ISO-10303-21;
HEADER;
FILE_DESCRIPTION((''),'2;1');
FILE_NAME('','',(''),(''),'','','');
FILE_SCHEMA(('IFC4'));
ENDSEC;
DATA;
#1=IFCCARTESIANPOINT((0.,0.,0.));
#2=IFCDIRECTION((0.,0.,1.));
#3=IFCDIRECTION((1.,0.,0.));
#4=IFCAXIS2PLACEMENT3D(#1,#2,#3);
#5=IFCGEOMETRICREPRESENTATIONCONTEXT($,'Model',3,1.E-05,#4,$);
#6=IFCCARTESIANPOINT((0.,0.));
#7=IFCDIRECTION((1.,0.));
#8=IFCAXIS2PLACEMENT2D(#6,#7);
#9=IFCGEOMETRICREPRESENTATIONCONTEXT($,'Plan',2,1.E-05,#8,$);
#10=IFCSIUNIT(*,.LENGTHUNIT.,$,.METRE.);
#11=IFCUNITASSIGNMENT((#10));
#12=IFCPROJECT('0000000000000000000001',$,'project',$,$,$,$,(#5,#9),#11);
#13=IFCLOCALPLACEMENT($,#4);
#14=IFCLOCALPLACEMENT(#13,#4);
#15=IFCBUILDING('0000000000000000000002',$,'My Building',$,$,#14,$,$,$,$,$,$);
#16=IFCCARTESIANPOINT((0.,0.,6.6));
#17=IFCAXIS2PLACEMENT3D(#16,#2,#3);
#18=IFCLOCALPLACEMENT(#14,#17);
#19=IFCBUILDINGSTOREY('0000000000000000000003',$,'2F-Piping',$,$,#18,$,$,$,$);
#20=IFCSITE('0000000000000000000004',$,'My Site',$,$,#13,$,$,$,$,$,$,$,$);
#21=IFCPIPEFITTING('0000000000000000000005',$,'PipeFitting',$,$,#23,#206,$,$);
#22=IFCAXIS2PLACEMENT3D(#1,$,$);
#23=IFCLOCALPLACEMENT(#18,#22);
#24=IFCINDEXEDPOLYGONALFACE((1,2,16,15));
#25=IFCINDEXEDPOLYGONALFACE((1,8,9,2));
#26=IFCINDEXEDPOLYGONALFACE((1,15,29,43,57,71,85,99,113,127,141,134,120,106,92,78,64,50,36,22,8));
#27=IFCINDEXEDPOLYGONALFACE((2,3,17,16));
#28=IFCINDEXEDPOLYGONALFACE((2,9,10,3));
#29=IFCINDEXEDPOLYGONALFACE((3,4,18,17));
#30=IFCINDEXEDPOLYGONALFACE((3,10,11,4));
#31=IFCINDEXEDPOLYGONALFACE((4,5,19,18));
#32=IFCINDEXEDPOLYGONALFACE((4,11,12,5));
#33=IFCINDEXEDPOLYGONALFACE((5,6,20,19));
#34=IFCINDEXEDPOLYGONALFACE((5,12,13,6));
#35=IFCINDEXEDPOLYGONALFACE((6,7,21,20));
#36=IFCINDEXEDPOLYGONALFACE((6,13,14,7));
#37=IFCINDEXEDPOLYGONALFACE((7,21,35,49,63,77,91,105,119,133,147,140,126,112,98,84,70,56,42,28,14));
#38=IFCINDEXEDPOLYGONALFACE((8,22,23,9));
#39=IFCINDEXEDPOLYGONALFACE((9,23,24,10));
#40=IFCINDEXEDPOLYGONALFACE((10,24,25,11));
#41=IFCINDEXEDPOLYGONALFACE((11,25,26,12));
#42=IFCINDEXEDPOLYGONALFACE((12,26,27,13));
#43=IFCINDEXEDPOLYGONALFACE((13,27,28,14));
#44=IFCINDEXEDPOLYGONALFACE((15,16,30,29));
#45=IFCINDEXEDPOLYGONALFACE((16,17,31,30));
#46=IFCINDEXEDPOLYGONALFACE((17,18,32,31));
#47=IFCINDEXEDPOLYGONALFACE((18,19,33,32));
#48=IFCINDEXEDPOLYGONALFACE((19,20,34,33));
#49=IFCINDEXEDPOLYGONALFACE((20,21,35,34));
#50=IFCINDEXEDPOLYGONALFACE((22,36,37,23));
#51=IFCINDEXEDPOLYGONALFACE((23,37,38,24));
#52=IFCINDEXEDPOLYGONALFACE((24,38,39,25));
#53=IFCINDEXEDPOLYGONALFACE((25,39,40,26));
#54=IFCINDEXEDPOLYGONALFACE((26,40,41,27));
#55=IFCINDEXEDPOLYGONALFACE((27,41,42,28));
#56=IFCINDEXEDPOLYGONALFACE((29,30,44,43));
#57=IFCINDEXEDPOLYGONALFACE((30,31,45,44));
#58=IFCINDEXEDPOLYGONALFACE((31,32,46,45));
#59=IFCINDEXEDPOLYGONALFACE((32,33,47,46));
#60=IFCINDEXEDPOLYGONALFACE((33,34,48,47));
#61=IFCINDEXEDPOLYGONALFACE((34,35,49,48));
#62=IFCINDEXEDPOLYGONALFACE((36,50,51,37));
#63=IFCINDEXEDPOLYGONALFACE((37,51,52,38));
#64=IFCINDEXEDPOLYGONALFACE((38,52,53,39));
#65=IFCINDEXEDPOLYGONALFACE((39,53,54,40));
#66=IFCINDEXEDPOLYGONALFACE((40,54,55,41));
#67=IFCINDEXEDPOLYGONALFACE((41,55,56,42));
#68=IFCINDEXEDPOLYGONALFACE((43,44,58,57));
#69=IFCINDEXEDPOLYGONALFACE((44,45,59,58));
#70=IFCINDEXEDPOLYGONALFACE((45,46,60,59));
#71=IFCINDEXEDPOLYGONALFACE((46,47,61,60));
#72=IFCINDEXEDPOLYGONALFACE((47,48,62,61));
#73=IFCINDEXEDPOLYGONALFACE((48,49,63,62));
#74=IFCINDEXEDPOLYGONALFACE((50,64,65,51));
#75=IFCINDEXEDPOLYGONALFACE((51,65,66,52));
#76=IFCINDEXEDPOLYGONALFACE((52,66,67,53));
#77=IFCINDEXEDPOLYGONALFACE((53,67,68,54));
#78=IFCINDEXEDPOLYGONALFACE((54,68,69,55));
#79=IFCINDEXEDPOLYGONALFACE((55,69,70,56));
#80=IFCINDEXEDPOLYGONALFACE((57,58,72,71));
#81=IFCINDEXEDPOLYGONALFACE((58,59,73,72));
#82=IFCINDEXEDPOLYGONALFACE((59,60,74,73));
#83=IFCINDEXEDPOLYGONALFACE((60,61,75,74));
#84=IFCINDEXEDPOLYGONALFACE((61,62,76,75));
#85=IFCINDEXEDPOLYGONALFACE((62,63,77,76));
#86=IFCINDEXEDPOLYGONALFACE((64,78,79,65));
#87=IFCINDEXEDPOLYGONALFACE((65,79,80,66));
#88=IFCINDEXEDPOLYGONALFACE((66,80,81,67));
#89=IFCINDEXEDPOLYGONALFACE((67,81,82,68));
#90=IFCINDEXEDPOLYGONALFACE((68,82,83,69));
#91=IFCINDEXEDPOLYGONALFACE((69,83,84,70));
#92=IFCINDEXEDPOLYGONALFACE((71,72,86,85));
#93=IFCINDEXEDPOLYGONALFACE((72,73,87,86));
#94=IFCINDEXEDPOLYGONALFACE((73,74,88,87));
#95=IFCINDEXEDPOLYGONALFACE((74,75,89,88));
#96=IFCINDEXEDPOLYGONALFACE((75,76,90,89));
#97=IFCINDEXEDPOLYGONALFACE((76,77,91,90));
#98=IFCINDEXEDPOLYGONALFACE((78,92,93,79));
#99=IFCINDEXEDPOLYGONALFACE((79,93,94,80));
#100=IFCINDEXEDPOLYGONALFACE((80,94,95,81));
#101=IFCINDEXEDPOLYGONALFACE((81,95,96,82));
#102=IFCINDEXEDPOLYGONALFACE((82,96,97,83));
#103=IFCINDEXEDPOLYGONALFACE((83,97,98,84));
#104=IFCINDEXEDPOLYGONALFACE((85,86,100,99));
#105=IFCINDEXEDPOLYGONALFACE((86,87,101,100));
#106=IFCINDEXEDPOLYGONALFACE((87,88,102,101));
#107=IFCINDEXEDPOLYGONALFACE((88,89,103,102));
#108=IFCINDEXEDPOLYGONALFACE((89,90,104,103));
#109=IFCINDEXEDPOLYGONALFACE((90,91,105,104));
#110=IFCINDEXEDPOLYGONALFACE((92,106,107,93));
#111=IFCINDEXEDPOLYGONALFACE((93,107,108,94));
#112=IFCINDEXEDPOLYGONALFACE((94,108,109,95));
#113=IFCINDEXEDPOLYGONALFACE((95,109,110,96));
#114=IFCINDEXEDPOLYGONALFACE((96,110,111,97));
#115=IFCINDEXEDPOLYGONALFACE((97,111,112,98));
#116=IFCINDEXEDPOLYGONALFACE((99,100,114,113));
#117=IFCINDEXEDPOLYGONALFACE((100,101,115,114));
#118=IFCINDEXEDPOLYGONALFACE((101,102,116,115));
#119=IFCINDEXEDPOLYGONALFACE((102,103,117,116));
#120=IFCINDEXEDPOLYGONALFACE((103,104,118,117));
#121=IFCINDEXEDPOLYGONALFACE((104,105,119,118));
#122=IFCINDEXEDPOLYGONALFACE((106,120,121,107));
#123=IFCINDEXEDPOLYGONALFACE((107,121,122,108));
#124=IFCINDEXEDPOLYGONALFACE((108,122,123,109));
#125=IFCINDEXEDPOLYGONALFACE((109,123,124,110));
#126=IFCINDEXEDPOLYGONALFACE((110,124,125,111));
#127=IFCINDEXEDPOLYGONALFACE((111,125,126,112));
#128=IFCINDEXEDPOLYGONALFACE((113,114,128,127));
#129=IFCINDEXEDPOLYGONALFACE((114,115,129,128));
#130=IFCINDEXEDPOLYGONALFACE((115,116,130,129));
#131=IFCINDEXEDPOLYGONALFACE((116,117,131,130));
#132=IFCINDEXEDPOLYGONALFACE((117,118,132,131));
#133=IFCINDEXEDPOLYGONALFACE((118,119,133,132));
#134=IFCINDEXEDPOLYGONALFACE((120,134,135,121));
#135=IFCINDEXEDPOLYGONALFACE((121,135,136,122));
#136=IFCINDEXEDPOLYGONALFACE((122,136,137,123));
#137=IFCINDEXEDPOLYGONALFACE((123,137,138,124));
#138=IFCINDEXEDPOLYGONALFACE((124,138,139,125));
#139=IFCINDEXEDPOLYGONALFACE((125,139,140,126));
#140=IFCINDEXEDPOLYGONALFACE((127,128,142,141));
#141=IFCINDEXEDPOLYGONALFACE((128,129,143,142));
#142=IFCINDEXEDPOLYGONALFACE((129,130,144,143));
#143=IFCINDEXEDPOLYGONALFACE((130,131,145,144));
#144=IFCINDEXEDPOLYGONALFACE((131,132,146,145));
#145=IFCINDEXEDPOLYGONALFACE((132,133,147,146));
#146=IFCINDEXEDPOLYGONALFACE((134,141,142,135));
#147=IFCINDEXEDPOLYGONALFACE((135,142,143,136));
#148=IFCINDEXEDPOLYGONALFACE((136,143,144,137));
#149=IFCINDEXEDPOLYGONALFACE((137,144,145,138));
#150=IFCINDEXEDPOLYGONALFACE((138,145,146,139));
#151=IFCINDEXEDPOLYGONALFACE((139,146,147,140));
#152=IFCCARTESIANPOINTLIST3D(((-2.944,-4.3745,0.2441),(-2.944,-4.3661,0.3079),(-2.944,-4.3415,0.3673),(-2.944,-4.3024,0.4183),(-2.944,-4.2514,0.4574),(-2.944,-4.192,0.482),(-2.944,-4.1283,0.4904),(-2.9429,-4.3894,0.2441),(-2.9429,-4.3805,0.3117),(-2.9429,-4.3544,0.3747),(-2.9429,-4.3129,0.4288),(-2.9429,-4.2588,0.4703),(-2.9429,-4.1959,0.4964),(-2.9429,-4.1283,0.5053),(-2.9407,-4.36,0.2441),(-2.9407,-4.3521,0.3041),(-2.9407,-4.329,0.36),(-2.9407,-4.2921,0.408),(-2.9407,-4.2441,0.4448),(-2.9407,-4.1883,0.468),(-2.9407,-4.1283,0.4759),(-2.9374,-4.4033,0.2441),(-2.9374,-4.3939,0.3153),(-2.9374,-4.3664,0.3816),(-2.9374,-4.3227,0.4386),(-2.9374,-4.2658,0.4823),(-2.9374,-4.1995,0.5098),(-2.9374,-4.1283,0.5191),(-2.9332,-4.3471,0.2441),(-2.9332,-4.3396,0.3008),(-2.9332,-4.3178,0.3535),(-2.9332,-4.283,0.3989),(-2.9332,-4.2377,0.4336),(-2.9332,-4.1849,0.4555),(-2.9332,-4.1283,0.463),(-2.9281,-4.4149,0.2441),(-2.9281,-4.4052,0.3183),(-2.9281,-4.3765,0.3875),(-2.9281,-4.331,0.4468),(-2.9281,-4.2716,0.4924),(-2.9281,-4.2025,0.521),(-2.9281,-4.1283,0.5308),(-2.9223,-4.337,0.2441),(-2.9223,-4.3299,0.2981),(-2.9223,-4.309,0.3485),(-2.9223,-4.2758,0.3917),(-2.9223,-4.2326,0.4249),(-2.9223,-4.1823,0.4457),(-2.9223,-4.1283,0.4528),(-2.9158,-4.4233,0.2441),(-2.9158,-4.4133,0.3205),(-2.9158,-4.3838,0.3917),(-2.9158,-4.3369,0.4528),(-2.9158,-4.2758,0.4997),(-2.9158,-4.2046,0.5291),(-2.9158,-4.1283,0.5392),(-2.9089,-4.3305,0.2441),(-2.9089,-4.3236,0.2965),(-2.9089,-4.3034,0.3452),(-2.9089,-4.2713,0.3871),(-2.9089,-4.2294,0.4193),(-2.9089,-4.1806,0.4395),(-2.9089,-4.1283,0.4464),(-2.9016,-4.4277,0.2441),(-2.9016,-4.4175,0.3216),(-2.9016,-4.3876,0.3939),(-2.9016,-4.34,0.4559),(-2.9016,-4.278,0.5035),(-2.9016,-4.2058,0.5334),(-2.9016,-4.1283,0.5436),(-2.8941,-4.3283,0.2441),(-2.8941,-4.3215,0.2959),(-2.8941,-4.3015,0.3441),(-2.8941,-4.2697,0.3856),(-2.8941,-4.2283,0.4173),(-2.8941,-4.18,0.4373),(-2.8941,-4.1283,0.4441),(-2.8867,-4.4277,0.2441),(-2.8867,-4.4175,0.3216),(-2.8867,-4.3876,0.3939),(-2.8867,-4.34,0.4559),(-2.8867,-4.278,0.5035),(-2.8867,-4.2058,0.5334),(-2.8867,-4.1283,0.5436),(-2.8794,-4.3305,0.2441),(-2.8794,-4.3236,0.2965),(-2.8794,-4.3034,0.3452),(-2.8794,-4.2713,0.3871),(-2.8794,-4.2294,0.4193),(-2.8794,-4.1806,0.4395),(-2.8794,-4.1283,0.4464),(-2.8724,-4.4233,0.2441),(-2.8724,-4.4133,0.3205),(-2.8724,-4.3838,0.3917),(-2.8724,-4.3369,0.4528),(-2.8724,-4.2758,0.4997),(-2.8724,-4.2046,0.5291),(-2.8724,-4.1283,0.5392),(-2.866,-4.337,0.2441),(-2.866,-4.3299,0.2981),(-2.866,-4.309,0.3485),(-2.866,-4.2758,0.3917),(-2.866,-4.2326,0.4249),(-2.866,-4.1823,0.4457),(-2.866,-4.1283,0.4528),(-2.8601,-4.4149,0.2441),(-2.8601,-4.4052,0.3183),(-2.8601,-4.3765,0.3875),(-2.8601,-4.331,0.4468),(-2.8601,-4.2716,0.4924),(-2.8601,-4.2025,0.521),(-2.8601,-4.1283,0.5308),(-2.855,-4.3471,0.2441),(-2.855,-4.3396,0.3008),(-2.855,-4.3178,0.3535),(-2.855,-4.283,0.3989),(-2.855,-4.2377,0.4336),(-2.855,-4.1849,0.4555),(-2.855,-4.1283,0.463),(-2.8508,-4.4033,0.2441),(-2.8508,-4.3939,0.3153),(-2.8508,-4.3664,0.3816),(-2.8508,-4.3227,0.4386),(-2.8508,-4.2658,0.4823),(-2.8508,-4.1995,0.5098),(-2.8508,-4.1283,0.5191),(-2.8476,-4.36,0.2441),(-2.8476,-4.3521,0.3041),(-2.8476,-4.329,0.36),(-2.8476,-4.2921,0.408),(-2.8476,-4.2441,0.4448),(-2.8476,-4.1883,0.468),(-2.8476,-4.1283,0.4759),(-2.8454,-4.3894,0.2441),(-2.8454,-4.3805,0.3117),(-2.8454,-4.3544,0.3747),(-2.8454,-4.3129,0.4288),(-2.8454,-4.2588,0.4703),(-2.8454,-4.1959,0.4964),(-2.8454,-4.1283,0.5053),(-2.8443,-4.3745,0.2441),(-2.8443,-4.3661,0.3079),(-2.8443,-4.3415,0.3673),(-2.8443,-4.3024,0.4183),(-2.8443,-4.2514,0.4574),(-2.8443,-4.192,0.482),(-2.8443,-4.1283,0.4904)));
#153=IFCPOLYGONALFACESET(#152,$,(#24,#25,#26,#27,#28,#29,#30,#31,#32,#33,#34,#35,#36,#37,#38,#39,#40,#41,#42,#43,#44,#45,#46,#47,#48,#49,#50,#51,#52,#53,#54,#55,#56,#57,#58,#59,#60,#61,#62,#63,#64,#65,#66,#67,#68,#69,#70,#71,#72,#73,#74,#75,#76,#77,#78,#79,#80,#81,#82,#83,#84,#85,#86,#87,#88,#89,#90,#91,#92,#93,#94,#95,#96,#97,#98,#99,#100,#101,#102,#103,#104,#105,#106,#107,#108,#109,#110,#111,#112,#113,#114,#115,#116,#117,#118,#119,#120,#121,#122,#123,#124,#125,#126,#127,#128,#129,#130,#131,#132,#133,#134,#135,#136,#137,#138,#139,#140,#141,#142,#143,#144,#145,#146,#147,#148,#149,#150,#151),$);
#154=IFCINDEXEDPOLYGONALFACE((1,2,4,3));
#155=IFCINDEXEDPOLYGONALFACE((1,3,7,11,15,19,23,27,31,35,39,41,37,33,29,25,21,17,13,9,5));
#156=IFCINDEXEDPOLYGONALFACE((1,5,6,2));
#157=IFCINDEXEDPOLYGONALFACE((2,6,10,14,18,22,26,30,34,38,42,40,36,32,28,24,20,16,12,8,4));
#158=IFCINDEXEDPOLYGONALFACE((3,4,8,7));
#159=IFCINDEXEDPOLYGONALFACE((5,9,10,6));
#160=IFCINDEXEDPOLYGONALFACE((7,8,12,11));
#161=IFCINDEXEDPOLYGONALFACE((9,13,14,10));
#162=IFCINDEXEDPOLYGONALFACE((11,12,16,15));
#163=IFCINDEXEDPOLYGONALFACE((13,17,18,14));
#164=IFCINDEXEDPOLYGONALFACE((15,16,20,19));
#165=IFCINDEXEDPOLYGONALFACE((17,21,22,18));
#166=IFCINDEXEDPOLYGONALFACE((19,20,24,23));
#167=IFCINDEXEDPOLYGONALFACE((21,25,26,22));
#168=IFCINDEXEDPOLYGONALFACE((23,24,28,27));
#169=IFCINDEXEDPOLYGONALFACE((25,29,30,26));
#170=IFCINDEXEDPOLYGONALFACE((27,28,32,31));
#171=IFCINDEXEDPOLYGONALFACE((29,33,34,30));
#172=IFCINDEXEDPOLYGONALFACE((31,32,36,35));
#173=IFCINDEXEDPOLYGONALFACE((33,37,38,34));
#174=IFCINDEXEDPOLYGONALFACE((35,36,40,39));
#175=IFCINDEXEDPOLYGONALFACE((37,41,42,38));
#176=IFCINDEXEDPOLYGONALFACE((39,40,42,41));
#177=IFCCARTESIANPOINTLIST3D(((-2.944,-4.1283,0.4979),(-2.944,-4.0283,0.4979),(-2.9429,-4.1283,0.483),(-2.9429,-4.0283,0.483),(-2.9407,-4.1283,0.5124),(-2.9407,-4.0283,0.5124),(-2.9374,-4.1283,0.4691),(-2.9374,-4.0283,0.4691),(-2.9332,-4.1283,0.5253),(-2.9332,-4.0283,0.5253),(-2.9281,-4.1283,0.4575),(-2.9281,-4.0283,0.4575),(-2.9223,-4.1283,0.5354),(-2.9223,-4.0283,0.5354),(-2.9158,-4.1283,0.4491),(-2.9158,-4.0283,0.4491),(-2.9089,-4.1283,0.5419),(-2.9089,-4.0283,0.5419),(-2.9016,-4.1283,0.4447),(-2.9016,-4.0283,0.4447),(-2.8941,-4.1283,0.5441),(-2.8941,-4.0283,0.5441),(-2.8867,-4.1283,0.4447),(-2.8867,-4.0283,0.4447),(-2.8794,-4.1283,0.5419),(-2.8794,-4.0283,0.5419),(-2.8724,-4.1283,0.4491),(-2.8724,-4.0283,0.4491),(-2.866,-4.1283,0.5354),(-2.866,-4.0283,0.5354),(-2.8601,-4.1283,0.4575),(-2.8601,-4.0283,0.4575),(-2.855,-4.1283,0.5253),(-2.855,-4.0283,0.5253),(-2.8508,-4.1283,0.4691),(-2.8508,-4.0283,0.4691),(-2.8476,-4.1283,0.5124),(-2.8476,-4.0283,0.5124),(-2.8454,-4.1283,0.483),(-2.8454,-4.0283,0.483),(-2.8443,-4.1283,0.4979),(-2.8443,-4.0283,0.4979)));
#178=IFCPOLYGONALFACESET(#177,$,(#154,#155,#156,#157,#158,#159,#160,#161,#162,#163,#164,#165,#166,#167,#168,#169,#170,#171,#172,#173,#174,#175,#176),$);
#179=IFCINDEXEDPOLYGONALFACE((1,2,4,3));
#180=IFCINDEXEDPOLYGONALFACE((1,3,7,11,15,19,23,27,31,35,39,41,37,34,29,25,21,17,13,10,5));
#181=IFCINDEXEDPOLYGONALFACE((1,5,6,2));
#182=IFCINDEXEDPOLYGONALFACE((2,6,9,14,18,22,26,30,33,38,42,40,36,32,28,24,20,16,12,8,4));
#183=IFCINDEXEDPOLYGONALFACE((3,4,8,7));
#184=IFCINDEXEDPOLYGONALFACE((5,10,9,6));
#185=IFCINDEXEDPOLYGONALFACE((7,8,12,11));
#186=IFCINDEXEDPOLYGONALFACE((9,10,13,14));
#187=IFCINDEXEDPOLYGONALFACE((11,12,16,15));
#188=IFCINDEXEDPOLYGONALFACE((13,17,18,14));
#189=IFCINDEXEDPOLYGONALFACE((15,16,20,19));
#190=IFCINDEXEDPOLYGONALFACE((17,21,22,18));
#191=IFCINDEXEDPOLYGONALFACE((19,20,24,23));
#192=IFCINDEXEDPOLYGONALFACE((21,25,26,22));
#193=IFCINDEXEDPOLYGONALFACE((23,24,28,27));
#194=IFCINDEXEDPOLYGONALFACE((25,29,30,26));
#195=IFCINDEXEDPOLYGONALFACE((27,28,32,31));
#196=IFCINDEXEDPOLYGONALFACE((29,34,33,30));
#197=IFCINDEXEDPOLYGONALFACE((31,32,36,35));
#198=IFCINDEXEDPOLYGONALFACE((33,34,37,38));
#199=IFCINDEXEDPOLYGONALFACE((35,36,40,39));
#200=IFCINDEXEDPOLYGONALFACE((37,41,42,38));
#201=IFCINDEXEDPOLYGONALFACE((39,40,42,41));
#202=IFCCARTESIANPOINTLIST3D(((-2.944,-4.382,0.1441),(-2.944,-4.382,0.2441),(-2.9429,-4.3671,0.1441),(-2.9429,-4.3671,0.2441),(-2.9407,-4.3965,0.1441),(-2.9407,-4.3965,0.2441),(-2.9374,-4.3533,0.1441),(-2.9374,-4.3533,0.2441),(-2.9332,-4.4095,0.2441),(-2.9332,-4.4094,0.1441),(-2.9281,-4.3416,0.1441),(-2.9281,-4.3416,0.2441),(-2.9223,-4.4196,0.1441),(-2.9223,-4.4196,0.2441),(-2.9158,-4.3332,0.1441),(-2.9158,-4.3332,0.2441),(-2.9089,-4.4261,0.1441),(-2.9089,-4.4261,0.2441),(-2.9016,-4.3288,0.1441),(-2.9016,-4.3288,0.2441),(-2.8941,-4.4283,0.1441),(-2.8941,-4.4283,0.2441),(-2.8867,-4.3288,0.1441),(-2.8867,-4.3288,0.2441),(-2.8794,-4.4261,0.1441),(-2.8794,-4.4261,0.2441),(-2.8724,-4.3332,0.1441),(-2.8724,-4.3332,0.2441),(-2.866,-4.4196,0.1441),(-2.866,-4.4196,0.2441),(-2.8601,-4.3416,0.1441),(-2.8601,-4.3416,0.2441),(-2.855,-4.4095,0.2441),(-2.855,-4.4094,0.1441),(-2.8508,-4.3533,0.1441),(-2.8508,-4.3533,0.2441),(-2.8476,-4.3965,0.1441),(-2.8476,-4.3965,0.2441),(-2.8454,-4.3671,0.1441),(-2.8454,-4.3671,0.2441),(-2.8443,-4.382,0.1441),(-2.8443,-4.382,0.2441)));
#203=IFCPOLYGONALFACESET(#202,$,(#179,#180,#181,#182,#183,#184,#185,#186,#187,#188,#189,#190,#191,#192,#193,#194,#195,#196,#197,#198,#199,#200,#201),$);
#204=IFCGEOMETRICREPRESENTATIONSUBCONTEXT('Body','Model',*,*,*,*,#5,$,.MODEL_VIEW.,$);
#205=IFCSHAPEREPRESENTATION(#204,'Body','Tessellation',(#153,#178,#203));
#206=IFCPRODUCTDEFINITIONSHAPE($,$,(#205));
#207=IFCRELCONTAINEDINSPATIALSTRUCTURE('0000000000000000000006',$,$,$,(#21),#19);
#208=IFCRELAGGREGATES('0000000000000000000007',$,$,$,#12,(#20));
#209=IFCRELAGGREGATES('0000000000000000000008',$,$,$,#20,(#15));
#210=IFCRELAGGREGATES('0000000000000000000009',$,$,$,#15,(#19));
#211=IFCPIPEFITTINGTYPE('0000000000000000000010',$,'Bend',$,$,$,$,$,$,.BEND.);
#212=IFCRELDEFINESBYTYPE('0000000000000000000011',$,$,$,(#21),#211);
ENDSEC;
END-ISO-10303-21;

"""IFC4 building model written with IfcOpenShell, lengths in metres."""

from ifc_helpers import new_model, entity, si_unit, frame, origin_with_axes, origin_2d_with_axis, place, context, subcontext, project, spatial, circle, extrude, source, transform, mapped, type_object, type_shapes, element, save


model = new_model("IFC4")

# Units and contexts
model_context = context("Model", 3, precision=1e-05, world=origin_with_axes())
plan_context = context("Plan", 2, precision=1e-05, world=origin_2d_with_axis())
body_context = subcontext(model_context, "Body", "Model", "MODEL_VIEW")
ifc_project = project(units=[si_unit("LENGTHUNIT", "METRE")], contexts=[model_context, plan_context])

# Site, building, storey
site_placement = place(None, origin_with_axes())
site = spatial("IfcSite", under=ifc_project, at=site_placement, Name="My Site")
building_placement = place(site_placement, origin_with_axes())
building = spatial("IfcBuilding", under=site, at=building_placement, Name="My Building")
storey_placement = place(building_placement, frame((0.0, 0.0, 6.6), z_axis=(0.0, 0.0, 1.0), x_axis=(1.0, 0.0, 0.0)))
storey = spatial("IfcBuildingStorey", under=building, at=storey_placement, Name="2F-Piping")

# Pipe fitting
pipe_fitting_type = type_object("IfcPipeFittingType", Name="Bend", PredefinedType="BEND")
shared_shape = source(origin_with_axes(), body_context, "Body", "SolidModel", [
    entity("IfcSweptDiskSolid", entity("IfcIndexedPolyCurve", entity("IfcCartesianPointList3D", [[0.0, 0.0, -0.1], [-0.0732, 0.0, -0.2768], [-0.25, 0.0, -0.35]]), [entity("IfcArcIndex", [1, 2, 3])]), 0.05),
    extrude(circle(Radius=0.05), origin_with_axes(), (0.0, 0.0, -1.0), 0.1),
    extrude(circle(Radius=0.05), frame((-0.25, 0.0, -0.35), z_axis=(-1.0, 0.0, 0.0), x_axis=(0.0, 0.0, -1.0)), (0.0, 0.0, 1.0), 0.1),
])
type_shapes(pipe_fitting_type, [shared_shape])
for number, where, z_axis, x_axis, name in (
    (1, (-2.8941, -4.0283, 0.4941), (0.0, 1.0, 0.0), (0.0, 0.0, 1.0), "PipeFitting"),
):
    element("IfcPipeFitting", number, at=place(storey_placement, frame(where, z_axis=z_axis, x_axis=x_axis)), inside=storey, type_object=pipe_fitting_type, Name=name, context=body_context, shape_type="MappedRepresentation", body=[
        mapped(shared_shape, transform((0.0, 0.0, 0.0), x_axis=(1.0, 0.0, 0.0), y_axis=(0.0, 1.0, 0.0), z_axis=(0.0, 0.0, 1.0), scale=1.0)),
    ])

save(model, "model.ifc")
